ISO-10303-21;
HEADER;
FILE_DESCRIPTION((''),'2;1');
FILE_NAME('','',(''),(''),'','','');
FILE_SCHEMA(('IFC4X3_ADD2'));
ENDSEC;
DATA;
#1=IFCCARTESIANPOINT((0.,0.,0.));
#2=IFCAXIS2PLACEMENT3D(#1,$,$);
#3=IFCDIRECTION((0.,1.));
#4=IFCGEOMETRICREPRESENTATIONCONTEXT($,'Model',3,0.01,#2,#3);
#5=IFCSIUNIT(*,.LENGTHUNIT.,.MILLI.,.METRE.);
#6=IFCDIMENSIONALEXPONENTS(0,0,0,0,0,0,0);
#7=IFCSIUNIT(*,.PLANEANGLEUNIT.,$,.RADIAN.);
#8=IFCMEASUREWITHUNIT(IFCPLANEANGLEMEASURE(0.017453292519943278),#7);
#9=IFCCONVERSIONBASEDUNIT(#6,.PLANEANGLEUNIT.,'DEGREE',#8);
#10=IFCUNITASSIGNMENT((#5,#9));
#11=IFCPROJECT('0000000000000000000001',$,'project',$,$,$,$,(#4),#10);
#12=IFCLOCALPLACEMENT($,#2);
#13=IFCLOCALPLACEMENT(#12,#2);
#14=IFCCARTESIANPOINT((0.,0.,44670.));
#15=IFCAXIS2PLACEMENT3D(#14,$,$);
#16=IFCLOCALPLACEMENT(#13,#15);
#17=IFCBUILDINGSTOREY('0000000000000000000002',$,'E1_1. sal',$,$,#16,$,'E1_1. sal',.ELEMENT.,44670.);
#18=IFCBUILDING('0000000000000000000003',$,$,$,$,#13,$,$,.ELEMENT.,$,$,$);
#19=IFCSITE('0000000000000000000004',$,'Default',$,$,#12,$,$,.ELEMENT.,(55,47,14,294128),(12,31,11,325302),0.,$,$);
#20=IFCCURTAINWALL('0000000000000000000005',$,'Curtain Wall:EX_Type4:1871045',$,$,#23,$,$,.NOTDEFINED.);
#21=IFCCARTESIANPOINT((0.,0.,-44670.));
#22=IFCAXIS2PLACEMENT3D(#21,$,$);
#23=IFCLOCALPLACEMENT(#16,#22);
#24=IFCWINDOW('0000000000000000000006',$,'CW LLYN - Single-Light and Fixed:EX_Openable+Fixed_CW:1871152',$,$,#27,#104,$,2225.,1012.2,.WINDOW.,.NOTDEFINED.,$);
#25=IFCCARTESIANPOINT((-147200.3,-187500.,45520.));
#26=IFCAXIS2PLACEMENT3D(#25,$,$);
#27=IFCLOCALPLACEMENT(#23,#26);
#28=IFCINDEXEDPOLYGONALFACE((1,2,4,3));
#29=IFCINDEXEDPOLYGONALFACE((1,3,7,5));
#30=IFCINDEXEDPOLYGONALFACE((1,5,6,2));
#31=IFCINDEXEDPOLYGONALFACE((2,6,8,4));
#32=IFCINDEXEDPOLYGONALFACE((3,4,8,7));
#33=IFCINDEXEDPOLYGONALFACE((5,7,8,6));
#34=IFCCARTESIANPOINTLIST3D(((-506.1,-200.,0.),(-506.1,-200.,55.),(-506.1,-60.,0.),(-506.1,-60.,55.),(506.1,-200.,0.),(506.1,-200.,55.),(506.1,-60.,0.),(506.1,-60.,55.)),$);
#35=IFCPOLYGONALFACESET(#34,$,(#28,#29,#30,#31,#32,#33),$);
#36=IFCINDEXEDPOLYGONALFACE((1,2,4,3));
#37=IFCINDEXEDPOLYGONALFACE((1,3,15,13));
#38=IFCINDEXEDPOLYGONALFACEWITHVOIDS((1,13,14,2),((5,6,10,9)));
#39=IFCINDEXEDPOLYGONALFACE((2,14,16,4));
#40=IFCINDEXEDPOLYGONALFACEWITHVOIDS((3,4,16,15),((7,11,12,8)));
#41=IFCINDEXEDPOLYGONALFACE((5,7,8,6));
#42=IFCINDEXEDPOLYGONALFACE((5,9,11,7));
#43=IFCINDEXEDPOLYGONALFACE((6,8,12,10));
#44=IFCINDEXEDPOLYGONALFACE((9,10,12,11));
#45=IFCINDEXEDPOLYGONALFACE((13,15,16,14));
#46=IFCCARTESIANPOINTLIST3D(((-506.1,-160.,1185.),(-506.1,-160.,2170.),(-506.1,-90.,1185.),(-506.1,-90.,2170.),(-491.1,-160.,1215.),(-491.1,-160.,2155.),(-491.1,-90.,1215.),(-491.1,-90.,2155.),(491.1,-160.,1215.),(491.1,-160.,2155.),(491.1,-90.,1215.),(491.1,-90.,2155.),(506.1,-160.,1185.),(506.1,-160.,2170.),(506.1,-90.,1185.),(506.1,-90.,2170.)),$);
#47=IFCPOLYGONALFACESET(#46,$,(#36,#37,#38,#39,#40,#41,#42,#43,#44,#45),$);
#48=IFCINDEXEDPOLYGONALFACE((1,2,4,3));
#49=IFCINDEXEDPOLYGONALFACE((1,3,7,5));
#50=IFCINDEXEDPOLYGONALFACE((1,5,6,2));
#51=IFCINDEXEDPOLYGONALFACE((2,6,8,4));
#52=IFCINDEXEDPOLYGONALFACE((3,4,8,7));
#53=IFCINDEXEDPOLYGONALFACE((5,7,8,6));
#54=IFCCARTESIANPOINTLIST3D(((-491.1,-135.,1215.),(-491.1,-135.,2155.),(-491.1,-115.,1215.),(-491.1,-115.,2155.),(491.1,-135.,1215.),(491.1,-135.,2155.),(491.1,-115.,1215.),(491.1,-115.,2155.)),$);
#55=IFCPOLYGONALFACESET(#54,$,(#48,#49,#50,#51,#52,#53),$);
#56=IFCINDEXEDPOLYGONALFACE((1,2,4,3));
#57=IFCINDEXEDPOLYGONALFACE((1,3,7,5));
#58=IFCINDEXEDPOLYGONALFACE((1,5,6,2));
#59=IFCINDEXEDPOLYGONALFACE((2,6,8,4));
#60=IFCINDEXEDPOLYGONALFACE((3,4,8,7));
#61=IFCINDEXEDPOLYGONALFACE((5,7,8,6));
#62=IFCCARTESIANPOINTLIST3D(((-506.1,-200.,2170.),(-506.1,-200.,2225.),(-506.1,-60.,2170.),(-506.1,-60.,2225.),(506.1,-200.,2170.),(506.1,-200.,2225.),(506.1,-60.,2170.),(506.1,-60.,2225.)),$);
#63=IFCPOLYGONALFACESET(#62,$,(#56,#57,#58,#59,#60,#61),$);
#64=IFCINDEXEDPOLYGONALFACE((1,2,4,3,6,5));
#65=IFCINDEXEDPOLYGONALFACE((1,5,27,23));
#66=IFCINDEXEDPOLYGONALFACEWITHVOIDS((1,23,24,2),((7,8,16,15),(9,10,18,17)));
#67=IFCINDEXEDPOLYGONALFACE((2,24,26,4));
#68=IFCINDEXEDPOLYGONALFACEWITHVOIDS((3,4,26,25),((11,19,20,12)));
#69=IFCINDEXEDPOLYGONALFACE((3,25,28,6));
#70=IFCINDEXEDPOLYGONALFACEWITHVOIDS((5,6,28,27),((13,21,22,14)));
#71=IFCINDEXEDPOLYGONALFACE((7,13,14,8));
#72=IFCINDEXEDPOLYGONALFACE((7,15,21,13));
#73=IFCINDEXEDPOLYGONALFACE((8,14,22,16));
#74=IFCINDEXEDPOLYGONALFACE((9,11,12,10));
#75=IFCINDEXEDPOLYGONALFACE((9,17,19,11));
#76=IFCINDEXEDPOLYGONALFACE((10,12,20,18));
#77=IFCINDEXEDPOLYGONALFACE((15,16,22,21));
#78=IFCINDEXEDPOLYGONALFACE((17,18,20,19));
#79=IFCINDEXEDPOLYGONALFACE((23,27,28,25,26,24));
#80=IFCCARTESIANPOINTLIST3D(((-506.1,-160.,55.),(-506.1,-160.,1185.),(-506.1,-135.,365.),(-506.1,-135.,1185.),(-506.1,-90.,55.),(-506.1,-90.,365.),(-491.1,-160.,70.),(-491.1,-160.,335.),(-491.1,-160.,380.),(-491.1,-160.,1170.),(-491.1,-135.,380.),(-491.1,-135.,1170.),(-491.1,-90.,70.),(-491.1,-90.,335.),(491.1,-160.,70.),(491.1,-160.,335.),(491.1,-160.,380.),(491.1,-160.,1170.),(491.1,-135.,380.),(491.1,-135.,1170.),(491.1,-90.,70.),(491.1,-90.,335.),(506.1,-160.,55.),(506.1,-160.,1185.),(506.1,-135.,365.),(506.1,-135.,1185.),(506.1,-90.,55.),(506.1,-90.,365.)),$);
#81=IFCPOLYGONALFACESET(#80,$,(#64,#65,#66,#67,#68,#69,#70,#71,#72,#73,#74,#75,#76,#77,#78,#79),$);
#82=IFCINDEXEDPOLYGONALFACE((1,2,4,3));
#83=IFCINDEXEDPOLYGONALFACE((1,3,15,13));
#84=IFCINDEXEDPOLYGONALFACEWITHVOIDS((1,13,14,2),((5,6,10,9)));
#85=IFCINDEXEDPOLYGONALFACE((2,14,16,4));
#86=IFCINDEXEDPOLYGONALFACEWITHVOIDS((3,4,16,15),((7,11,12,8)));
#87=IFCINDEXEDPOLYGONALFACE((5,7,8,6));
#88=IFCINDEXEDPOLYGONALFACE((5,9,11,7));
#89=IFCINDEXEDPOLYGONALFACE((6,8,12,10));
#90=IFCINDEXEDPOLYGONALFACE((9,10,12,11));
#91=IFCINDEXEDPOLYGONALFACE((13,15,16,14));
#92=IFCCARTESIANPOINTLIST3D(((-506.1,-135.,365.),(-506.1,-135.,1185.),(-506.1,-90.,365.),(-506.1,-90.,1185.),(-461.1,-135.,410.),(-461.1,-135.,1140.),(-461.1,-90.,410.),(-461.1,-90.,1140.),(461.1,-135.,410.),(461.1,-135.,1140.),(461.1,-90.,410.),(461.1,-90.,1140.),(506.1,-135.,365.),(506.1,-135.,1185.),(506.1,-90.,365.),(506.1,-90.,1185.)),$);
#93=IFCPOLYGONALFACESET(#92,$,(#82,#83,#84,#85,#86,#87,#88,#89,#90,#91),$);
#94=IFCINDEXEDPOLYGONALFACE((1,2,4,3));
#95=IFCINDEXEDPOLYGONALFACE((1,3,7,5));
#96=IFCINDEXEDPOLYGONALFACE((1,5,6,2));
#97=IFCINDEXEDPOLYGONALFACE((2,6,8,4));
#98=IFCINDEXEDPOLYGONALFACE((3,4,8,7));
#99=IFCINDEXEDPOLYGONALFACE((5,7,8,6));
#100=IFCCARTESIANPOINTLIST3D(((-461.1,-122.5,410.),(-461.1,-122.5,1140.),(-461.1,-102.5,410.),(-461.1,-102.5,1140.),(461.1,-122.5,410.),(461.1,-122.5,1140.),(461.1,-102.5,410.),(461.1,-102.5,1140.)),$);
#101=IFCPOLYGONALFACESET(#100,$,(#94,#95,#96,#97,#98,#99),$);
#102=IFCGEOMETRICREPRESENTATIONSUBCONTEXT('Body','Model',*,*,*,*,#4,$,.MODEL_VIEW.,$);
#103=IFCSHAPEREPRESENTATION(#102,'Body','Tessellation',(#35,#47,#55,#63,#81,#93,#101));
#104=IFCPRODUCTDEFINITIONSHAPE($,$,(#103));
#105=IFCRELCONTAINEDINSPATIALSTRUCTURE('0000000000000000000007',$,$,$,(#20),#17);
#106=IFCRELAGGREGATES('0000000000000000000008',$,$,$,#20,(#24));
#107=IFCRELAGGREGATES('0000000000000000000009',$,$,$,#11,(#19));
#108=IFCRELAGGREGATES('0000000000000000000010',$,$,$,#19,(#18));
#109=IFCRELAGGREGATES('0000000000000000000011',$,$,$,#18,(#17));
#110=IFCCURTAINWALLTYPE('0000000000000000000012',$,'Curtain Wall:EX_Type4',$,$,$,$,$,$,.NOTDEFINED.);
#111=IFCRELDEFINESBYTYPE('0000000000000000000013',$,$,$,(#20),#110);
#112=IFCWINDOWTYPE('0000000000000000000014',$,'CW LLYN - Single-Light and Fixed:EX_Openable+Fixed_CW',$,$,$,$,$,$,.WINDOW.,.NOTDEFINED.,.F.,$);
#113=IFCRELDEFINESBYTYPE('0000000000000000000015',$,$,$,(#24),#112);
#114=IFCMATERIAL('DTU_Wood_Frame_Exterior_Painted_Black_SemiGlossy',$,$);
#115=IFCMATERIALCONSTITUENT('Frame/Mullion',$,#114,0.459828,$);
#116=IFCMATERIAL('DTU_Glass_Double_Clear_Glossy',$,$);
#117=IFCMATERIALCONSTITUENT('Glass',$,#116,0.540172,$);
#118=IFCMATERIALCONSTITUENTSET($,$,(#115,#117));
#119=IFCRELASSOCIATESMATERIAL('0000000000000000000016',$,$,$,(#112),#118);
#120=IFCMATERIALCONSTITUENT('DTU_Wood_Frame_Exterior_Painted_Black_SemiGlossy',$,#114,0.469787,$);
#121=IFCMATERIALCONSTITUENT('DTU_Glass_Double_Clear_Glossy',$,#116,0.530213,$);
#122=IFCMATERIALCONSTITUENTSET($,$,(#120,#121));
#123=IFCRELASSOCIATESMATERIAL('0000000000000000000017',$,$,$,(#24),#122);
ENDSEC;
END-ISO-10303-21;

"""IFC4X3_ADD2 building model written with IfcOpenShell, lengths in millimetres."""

from ifc_helpers import new_model, entity, si_unit, converted_unit, direction, frame, frame_2d, origin, origin_2d_with_axis, place, context, subcontext, project, spatial, polyline, rectangle, outline, extrude, source, transform, mapped, material, constituent, constituent_set, type_object, type_shapes, element, aggregate, save


model = new_model("IFC4X3_ADD2")

# Units and contexts
model_context = context("Model", 3, precision=0.01, world=origin(), true_north=direction((0.0, 1.0)))
body_context = subcontext(model_context, "Body", "Model", "MODEL_VIEW")
ifc_project = project(units=[si_unit("LENGTHUNIT", "METRE", prefix="MILLI"), converted_unit("PLANEANGLEUNIT", "DEGREE", entity("IfcPlaneAngleMeasure", 0.017453292519943278), si_unit("PLANEANGLEUNIT", "RADIAN"), dimensions=[0, 0, 0, 0, 0, 0, 0])], contexts=[model_context])

# Site, building, storey
site_placement = place(None, origin())
site = spatial("IfcSite", under=ifc_project, at=site_placement, Name="Default", CompositionType="ELEMENT", RefLatitude=(55, 47, 14, 294128), RefLongitude=(12, 31, 11, 325302), RefElevation=0.0)
building_placement = place(site_placement, origin())
building = spatial("IfcBuilding", under=site, at=building_placement, CompositionType="ELEMENT")
storey_placement = place(building_placement, frame((0.0, 0.0, 44670.0)))
storey = spatial("IfcBuildingStorey", under=building, at=storey_placement, Name="E1_1. sal", LongName="E1_1. sal", CompositionType="ELEMENT", Elevation=44670.0)

# Curtain wall
curtain_wall_type = type_object("IfcCurtainWallType", Name="Curtain Wall:EX_Type4", PredefinedType="NOTDEFINED")
curtain_wall_placement = place(storey_placement, frame((0.0, 0.0, -44670.0)))
curtain_wall = element("IfcCurtainWall", 1, at=curtain_wall_placement, inside=storey, type_object=curtain_wall_type, Name="Curtain Wall:EX_Type4:1871045", PredefinedType="NOTDEFINED")

# Shared definitions
ifc_material_1 = material(Name="DTU_Wood_Frame_Exterior_Painted_Black_SemiGlossy")
ifc_material_2 = material(Name="DTU_Glass_Double_Clear_Glossy")

# Window, openings
ifc_constituent_1 = constituent(ifc_material_1, Name="DTU_Wood_Frame_Exterior_Painted_Black_SemiGlossy", fraction=0.469787)
ifc_constituent_2 = constituent(ifc_material_2, Name="DTU_Glass_Double_Clear_Glossy", fraction=0.530213)
ifc_constituent_set_1 = constituent_set(constituents=[ifc_constituent_1, ifc_constituent_2])
ifc_constituent_3 = constituent(ifc_material_1, Name="Frame/Mullion", fraction=0.459828)
ifc_constituent_4 = constituent(ifc_material_2, Name="Glass", fraction=0.540172)
ifc_constituent_set_2 = constituent_set(constituents=[ifc_constituent_3, ifc_constituent_4])
window_type_1 = type_object("IfcWindowType", Name="CW LLYN - Single-Light and Fixed:EX_Openable+Fixed_CW", ParameterTakesPrecedence=False, PartitioningType="NOTDEFINED", PredefinedType="WINDOW", material=ifc_constituent_set_2)
shared_shape_1 = source(origin(), body_context, "Body", "SweptSolid", [
    extrude(rectangle(XDim=1012.2, YDim=140.0, at=origin_2d_with_axis()), frame((0.0, -130.0, 0.0), z_axis=(0.0, 0.0, 1.0), x_axis=(-1.0, 0.0, 0.0)), (0.0, 0.0, 1.0), 55.0),
    extrude(outline(polyline([(-492.5, -506.1), (492.5, -506.1), (492.5, 506.1), (-492.5, 506.1), (-492.5, -506.1)]), holes=[polyline([(477.5, -491.1), (-462.5, -491.1), (-462.5, 491.1), (477.5, 491.1), (477.5, -491.1)])]), frame((0.0, -160.0, 1677.5), z_axis=(0.0, 1.0, 0.0), x_axis=(0.0, 0.0, 1.0)), (0.0, 0.0, 1.0), 70.0),
    extrude(rectangle(XDim=20.0, YDim=982.2, at=frame_2d((0.0, 0.0), x_axis=(1.0, 0.0))), frame((0.0, -125.0, 1215.0), z_axis=(0.0, 0.0, 1.0), x_axis=(0.0, -1.0, 0.0)), (0.0, 0.0, 1.0), 940.0),
    extrude(rectangle(XDim=20.0, YDim=982.2, at=frame_2d((0.0, 0.0), x_axis=(1.0, 0.0))), frame((0.0, -125.0, 70.0), z_axis=(0.0, 0.0, 1.0), x_axis=(0.0, -1.0, 0.0)), (0.0, 0.0, 1.0), 265.0),
    extrude(rectangle(XDim=1012.2, YDim=140.0, at=origin_2d_with_axis()), frame((0.0, -130.0, 2170.0), z_axis=(0.0, 0.0, 1.0), x_axis=(-1.0, 0.0, 0.0)), (0.0, 0.0, 1.0), 55.0),
    extrude(outline(polyline([(-480.0, -38.3), (-170.0, -38.3), (-170.0, 6.7), (650.0, 6.7), (650.0, 31.7), (-480.0, 31.7), (-480.0, -38.3)])), frame((-506.1, -128.3, 535.0), z_axis=(1.0, 0.0, 0.0), x_axis=(0.0, 0.0, 1.0)), (0.0, 0.0, 1.0), 1012.2),
    extrude(outline(polyline([(-506.1, -410.0), (506.1, -410.0), (506.1, 410.0), (-506.1, 410.0), (-506.1, -410.0)]), holes=[polyline([(461.1, -365.0), (-461.1, -365.0), (-461.1, 365.0), (461.1, 365.0), (461.1, -365.0)])]), frame((0.0, -135.0, 775.0), z_axis=(0.0, 1.0, 0.0), x_axis=(-1.0, 0.0, 0.0)), (0.0, 0.0, 1.0), 45.0),
    extrude(rectangle(XDim=20.0, YDim=922.2, at=frame_2d((0.0, 0.0), x_axis=(1.0, 0.0))), frame((0.0, -112.5, 410.0), z_axis=(0.0, 0.0, 1.0), x_axis=(0.0, -1.0, 0.0)), (0.0, 0.0, 1.0), 730.0),
])
type_shapes(window_type_1, [shared_shape_1])
window_1_placement = place(curtain_wall_placement, frame((-147200.3, -187500.0, 45520.0)))
window_1 = element("IfcWindow", 2, at=window_1_placement, type_object=window_type_1, material=ifc_constituent_set_1, Name="CW LLYN - Single-Light and Fixed:EX_Openable+Fixed_CW:1871152", OverallHeight=2225.0, OverallWidth=1012.2, PartitioningType="NOTDEFINED", PredefinedType="WINDOW", context=body_context, shape_type="MappedRepresentation", body=[
    mapped(shared_shape_1, transform((0.0, 0.0, 0.0), scale=1.0)),
])
opening_1_placement = place(curtain_wall_placement, frame((-147200.3, -187500.0, 90190.0)))
opening_1 = element("IfcOpeningElement", 3, at=opening_1_placement, cuts=window_1, PredefinedType="OPENING", context=body_context, shape_type="SweptSolid", body=[
    extrude(rectangle(XDim=265.0, YDim=982.2, at=frame_2d((0.0, 0.0), x_axis=(0.0, 1.0))), frame((0.0, -160.0, -44467.5), z_axis=(0.0, 1.0, 0.0), x_axis=(-1.0, 0.0, 0.0)), (0.0, 0.0, 1.0), 70.0),
])
opening_2_placement = place(curtain_wall_placement, frame((-147200.3, -187500.0, 90190.0)))
opening_2 = element("IfcOpeningElement", 4, at=opening_2_placement, cuts=window_1, PredefinedType="OPENING", context=body_context, shape_type="SweptSolid", body=[
    extrude(rectangle(XDim=790.0, YDim=982.2, at=frame_2d((0.0, 0.0), x_axis=(0.0, 1.0))), frame((0.0, -135.0, -43895.0), z_axis=(0.0, -1.0, 0.0), x_axis=(1.0, 0.0, 0.0)), (0.0, 0.0, 1.0), 25.0),
])

aggregate(curtain_wall, [window_1, opening_1, opening_2])

save(model, "model.ifc")
